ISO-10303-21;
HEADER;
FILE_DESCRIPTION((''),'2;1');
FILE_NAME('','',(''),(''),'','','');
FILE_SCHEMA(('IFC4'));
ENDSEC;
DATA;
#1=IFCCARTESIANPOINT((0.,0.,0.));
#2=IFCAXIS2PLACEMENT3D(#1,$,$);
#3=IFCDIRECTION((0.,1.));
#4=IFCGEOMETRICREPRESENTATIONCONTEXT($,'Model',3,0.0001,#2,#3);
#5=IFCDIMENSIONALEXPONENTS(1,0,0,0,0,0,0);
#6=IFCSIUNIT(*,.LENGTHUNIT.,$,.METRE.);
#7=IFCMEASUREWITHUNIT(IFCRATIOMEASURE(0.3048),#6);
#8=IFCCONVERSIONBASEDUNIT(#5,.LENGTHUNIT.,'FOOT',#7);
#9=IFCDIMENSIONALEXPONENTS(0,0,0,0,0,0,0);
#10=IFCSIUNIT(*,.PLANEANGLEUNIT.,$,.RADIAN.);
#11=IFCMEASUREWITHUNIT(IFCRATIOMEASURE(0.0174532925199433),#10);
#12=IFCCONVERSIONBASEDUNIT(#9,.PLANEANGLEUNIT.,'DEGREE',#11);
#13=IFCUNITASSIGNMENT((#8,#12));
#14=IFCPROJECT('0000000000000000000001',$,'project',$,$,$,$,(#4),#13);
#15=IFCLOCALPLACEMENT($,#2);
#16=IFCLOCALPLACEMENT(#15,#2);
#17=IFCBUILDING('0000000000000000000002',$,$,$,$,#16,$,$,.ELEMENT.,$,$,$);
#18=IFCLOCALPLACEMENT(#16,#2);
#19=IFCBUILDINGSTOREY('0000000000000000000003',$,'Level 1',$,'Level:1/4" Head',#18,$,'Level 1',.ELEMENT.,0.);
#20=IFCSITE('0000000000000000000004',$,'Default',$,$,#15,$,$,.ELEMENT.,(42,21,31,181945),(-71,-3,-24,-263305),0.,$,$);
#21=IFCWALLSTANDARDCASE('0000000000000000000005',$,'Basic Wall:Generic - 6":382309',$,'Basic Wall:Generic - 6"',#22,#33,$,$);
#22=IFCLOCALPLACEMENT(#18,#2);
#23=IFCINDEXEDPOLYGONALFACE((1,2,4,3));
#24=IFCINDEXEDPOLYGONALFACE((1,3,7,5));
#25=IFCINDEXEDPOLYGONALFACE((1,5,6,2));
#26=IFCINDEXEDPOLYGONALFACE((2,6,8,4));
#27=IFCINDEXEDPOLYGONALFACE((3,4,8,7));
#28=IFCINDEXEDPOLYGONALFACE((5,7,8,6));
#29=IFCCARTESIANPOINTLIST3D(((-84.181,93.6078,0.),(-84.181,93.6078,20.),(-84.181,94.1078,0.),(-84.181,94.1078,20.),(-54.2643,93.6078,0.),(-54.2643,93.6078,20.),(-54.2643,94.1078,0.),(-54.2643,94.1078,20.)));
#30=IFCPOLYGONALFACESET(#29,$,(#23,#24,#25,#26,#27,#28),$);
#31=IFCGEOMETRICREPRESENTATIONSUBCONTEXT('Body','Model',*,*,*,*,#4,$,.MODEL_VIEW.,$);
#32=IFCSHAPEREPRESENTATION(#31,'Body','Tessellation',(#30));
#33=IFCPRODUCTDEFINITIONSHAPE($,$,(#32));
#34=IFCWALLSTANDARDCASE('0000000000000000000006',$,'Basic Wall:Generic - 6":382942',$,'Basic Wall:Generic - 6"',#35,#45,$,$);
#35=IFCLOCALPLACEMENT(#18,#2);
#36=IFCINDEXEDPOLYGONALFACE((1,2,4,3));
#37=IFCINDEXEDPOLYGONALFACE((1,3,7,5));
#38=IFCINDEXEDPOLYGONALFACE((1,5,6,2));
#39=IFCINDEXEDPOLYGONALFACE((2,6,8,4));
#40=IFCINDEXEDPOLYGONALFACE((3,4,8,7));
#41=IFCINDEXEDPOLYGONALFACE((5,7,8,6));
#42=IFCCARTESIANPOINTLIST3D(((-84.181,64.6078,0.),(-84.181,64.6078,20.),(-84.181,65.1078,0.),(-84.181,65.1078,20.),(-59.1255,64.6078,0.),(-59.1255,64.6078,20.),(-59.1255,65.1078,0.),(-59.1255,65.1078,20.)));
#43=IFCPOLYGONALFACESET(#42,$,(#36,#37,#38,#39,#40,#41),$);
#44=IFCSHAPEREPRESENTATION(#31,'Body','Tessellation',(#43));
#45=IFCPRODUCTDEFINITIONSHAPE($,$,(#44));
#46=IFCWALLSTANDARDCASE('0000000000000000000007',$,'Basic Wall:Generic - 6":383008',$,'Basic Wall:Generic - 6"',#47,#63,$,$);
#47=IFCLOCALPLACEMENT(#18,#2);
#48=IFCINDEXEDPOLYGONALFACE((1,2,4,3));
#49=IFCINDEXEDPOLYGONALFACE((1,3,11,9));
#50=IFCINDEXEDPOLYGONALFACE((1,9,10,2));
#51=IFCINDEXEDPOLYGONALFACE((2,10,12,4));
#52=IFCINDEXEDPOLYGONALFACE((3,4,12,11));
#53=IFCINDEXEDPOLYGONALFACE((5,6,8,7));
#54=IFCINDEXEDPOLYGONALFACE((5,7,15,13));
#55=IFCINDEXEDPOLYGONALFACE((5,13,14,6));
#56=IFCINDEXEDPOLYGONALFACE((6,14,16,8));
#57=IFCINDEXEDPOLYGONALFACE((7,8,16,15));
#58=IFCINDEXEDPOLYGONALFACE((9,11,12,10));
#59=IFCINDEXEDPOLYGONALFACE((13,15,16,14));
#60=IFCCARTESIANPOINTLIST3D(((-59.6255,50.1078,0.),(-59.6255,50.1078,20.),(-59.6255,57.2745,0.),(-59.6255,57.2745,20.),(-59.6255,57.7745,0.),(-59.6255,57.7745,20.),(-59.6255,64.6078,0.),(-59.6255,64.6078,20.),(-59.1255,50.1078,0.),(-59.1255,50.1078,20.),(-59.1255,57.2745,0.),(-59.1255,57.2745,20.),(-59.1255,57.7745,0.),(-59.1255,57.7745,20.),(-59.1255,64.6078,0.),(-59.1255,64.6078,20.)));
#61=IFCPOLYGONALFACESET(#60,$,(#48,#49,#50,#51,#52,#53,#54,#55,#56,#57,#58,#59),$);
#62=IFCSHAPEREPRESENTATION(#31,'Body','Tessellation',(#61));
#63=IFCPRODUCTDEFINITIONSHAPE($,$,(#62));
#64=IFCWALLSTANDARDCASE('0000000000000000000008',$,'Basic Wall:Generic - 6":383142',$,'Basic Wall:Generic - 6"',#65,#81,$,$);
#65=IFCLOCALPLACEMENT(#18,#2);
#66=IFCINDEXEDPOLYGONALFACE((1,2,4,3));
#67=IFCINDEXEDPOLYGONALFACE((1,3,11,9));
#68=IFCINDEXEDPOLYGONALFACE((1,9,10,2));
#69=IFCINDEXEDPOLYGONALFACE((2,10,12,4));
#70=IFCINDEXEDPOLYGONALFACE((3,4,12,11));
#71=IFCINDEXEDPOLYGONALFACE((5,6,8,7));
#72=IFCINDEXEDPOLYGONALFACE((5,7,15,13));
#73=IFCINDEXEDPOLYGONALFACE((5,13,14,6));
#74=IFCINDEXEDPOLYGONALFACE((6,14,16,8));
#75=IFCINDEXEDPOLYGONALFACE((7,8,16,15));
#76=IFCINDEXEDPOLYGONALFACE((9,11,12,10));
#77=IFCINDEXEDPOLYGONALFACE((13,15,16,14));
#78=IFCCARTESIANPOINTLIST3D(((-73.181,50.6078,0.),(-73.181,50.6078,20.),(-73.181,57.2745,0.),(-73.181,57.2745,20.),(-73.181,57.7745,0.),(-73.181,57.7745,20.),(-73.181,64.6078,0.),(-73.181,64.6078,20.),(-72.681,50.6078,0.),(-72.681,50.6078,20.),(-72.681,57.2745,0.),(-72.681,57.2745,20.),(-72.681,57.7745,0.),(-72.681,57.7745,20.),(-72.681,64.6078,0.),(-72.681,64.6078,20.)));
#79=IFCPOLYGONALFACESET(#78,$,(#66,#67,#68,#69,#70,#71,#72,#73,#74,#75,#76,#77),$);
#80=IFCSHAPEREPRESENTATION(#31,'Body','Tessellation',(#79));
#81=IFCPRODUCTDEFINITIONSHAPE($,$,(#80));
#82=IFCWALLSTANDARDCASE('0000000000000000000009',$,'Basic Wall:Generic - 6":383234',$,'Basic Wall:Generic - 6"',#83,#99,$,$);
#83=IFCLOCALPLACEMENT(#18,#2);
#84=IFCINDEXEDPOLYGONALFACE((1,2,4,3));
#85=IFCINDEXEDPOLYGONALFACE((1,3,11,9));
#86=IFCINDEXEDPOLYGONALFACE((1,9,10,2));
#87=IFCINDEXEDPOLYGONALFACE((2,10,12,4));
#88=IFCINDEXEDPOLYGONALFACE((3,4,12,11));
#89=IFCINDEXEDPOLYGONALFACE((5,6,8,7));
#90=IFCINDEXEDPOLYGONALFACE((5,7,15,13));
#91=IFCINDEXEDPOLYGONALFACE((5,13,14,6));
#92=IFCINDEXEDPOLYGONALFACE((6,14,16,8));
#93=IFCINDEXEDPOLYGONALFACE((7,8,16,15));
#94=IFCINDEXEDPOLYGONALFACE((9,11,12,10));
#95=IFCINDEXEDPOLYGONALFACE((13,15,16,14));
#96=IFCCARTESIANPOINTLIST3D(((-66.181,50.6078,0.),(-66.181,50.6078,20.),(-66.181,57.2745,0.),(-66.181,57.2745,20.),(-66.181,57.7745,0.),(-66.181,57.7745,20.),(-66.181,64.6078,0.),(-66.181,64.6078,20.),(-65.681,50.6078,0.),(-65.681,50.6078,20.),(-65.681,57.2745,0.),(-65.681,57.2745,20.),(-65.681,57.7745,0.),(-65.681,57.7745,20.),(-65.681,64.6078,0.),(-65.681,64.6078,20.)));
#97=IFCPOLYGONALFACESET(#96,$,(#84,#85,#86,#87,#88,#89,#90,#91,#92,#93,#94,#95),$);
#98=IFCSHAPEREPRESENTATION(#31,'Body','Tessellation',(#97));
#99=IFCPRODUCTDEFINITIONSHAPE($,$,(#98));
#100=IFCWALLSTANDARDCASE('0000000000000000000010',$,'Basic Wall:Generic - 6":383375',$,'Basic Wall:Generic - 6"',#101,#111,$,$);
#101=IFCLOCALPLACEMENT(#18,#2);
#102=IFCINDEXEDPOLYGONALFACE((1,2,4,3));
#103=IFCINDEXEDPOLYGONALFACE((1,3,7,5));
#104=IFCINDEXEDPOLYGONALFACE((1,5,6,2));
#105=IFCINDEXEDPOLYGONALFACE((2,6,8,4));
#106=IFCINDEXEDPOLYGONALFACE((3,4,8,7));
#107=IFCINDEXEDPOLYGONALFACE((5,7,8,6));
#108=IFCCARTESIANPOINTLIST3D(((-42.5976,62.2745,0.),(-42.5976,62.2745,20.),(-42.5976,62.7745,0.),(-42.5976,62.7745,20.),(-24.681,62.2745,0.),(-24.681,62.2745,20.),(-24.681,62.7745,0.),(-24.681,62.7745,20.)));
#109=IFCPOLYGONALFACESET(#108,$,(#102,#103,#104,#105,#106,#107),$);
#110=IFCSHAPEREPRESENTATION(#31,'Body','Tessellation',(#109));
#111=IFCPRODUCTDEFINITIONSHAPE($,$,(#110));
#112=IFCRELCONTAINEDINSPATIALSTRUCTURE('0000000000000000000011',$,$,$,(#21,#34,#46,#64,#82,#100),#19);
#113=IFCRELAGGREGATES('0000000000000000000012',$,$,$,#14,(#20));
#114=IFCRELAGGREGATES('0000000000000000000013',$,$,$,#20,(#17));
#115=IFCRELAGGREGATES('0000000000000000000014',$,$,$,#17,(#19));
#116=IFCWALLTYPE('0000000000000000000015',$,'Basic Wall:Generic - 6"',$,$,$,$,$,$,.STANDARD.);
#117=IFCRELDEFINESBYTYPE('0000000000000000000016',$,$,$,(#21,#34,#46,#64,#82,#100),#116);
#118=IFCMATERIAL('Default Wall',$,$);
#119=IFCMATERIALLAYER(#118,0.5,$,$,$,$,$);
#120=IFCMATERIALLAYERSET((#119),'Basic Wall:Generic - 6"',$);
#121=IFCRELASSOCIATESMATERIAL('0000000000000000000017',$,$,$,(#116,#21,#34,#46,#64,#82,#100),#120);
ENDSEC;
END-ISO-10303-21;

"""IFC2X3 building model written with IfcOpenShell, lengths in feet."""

from ifc_helpers import new_model, entity, si_unit, converted_unit, direction, frame, frame_2d, origin, origin_2d_with_axis, place, context, subcontext, project, spatial, rectangle, extrude, material, layer, layer_set, layer_usage, type_object, element, save


model = new_model("IFC2X3")

# Units and contexts
model_context = context("Model", 3, precision=0.0001, world=origin(), true_north=direction((0.0, 1.0)))
body_context = subcontext(model_context, "Body", "Model", "MODEL_VIEW")
ifc_project = project(units=[converted_unit("LENGTHUNIT", "FOOT", entity("IfcRatioMeasure", 0.3048), si_unit("LENGTHUNIT", "METRE"), dimensions=[1, 0, 0, 0, 0, 0, 0]), converted_unit("PLANEANGLEUNIT", "DEGREE", entity("IfcRatioMeasure", 0.0174532925199433), si_unit("PLANEANGLEUNIT", "RADIAN"), dimensions=[0, 0, 0, 0, 0, 0, 0])], contexts=[model_context])

# Site, building, storey
site_placement = place(None, origin())
site = spatial("IfcSite", under=ifc_project, at=site_placement, Name="Default", CompositionType="ELEMENT", RefLatitude=(42, 21, 31, 181945), RefLongitude=(-71, -3, -24, -263305), RefElevation=0.0)
building_placement = place(site_placement, origin())
building = spatial("IfcBuilding", under=site, at=building_placement, CompositionType="ELEMENT")
storey_placement = place(building_placement, origin())
storey = spatial("IfcBuildingStorey", under=building, at=storey_placement, Name="Level 1", ObjectType="Level:1/4\" Head", LongName="Level 1", CompositionType="ELEMENT", Elevation=0.0)

# Walls
ifc_material = material(Name="Default Wall")
ifc_layer_1 = layer(ifc_material, 0.5)
ifc_layer_set_1 = layer_set([ifc_layer_1], Name="Basic Wall:Generic - 6\"")
wall_type_1 = type_object("IfcWallType", Name="Basic Wall:Generic - 6\"", PredefinedType="STANDARD", material=ifc_layer_set_1)
ifc_layer_usage_1 = layer_usage(ifc_layer_set_1, "AXIS2", "NEGATIVE", 0.25)
wall_1_placement = place(storey_placement, frame((-84.181, 93.8578, 0.0)))
element("IfcWallStandardCase", 1, at=wall_1_placement, inside=storey, type_object=wall_type_1, material=ifc_layer_usage_1, Name="Basic Wall:Generic - 6\":382309", ObjectType="Basic Wall:Generic - 6\"", context=body_context, shape_type="SweptSolid", body=[
    extrude(rectangle(XDim=29.9167, YDim=0.5, at=frame_2d((14.9583, 0.0), x_axis=(-1.0, 0.0))), origin(), (0.0, 0.0, 1.0), 20.0),
])
ifc_layer_usage_2 = layer_usage(ifc_layer_set_1, "AXIS2", "NEGATIVE", 0.25)
wall_2_placement = place(storey_placement, frame((-84.181, 64.8578, 0.0)))
element("IfcWallStandardCase", 2, at=wall_2_placement, inside=storey, type_object=wall_type_1, material=ifc_layer_usage_2, Name="Basic Wall:Generic - 6\":382942", ObjectType="Basic Wall:Generic - 6\"", context=body_context, shape_type="SweptSolid", body=[
    extrude(rectangle(XDim=25.0555, YDim=0.5, at=frame_2d((12.5278, 0.0), x_axis=(-1.0, 0.0))), origin(), (0.0, 0.0, 1.0), 20.0),
])

# Walls, openings
ifc_layer_usage_3 = layer_usage(ifc_layer_set_1, "AXIS2", "NEGATIVE", 0.25)
wall_3_placement = place(storey_placement, frame((-59.3755, 64.6078, 0.0), z_axis=(0.0, 0.0, 1.0), x_axis=(0.0, -1.0, 0.0)))
wall_3 = element("IfcWallStandardCase", 3, at=wall_3_placement, inside=storey, type_object=wall_type_1, material=ifc_layer_usage_3, Name="Basic Wall:Generic - 6\":383008", ObjectType="Basic Wall:Generic - 6\"", context=body_context, shape_type="SweptSolid", body=[
    extrude(rectangle(XDim=14.5, YDim=0.5, at=frame_2d((7.25, 0.0), x_axis=(-1.0, 0.0))), origin(), (0.0, 0.0, 1.0), 20.0),
])
opening_1_placement = place(storey_placement, frame((-59.3755, 64.6078, 0.0), z_axis=(0.0, 0.0, 1.0), x_axis=(0.0, -1.0, 0.0)))
element("IfcOpeningElement", 4, at=opening_1_placement, cuts=wall_3, ObjectType="Opening", context=body_context, shape_type="SweptSolid", body=[
    extrude(rectangle(XDim=20.0, YDim=0.5, at=origin_2d_with_axis()), frame((7.3333, 0.0, 10.0), z_axis=(-1.0, 0.0, 0.0), x_axis=(0.0, 0.0, 1.0)), (0.0, 0.0, 1.0), 0.5),
])
ifc_layer_usage_4 = layer_usage(ifc_layer_set_1, "AXIS2", "NEGATIVE", 0.25)
wall_4_placement = place(storey_placement, frame((-72.931, 64.6078, 0.0), z_axis=(0.0, 0.0, 1.0), x_axis=(0.0, -1.0, 0.0)))
wall_4 = element("IfcWallStandardCase", 5, at=wall_4_placement, inside=storey, type_object=wall_type_1, material=ifc_layer_usage_4, Name="Basic Wall:Generic - 6\":383142", ObjectType="Basic Wall:Generic - 6\"", context=body_context, shape_type="SweptSolid", body=[
    extrude(rectangle(XDim=14.0, YDim=0.5, at=frame_2d((7.0, 0.0), x_axis=(-1.0, 0.0))), origin(), (0.0, 0.0, 1.0), 20.0),
])
opening_2_placement = place(storey_placement, frame((-72.931, 64.6078, 0.0), z_axis=(0.0, 0.0, 1.0), x_axis=(0.0, -1.0, 0.0)))
element("IfcOpeningElement", 6, at=opening_2_placement, cuts=wall_4, ObjectType="Opening", context=body_context, shape_type="SweptSolid", body=[
    extrude(rectangle(XDim=20.0, YDim=0.5, at=origin_2d_with_axis()), frame((7.3333, 0.0, 10.0), z_axis=(-1.0, 0.0, 0.0), x_axis=(0.0, 0.0, 1.0)), (0.0, 0.0, 1.0), 0.5),
])
ifc_layer_usage_5 = layer_usage(ifc_layer_set_1, "AXIS2", "NEGATIVE", 0.25)
wall_5_placement = place(storey_placement, frame((-65.931, 64.6078, 0.0), z_axis=(0.0, 0.0, 1.0), x_axis=(0.0, -1.0, 0.0)))
wall_5 = element("IfcWallStandardCase", 7, at=wall_5_placement, inside=storey, type_object=wall_type_1, material=ifc_layer_usage_5, Name="Basic Wall:Generic - 6\":383234", ObjectType="Basic Wall:Generic - 6\"", context=body_context, shape_type="SweptSolid", body=[
    extrude(rectangle(XDim=14.0, YDim=0.5, at=frame_2d((7.0, 0.0), x_axis=(-1.0, 0.0))), origin(), (0.0, 0.0, 1.0), 20.0),
])
opening_3_placement = place(storey_placement, frame((-65.931, 64.6078, 0.0), z_axis=(0.0, 0.0, 1.0), x_axis=(0.0, -1.0, 0.0)))
element("IfcOpeningElement", 8, at=opening_3_placement, cuts=wall_5, ObjectType="Opening", context=body_context, shape_type="SweptSolid", body=[
    extrude(rectangle(XDim=20.0, YDim=0.5, at=origin_2d_with_axis()), frame((7.3333, 0.0, 10.0), z_axis=(-1.0, 0.0, 0.0), x_axis=(0.0, 0.0, 1.0)), (0.0, 0.0, 1.0), 0.5),
])

# Wall
ifc_layer_usage_6 = layer_usage(ifc_layer_set_1, "AXIS2", "NEGATIVE", 0.25)
wall_6_placement = place(storey_placement, frame((-42.5976, 62.5245, 0.0)))
element("IfcWallStandardCase", 9, at=wall_6_placement, inside=storey, type_object=wall_type_1, material=ifc_layer_usage_6, Name="Basic Wall:Generic - 6\":383375", ObjectType="Basic Wall:Generic - 6\"", context=body_context, shape_type="SweptSolid", body=[
    extrude(rectangle(XDim=17.9167, YDim=0.5, at=frame_2d((8.9583, 0.0), x_axis=(-1.0, 0.0))), origin(), (0.0, 0.0, 1.0), 20.0),
])

save(model, "model.ifc")
